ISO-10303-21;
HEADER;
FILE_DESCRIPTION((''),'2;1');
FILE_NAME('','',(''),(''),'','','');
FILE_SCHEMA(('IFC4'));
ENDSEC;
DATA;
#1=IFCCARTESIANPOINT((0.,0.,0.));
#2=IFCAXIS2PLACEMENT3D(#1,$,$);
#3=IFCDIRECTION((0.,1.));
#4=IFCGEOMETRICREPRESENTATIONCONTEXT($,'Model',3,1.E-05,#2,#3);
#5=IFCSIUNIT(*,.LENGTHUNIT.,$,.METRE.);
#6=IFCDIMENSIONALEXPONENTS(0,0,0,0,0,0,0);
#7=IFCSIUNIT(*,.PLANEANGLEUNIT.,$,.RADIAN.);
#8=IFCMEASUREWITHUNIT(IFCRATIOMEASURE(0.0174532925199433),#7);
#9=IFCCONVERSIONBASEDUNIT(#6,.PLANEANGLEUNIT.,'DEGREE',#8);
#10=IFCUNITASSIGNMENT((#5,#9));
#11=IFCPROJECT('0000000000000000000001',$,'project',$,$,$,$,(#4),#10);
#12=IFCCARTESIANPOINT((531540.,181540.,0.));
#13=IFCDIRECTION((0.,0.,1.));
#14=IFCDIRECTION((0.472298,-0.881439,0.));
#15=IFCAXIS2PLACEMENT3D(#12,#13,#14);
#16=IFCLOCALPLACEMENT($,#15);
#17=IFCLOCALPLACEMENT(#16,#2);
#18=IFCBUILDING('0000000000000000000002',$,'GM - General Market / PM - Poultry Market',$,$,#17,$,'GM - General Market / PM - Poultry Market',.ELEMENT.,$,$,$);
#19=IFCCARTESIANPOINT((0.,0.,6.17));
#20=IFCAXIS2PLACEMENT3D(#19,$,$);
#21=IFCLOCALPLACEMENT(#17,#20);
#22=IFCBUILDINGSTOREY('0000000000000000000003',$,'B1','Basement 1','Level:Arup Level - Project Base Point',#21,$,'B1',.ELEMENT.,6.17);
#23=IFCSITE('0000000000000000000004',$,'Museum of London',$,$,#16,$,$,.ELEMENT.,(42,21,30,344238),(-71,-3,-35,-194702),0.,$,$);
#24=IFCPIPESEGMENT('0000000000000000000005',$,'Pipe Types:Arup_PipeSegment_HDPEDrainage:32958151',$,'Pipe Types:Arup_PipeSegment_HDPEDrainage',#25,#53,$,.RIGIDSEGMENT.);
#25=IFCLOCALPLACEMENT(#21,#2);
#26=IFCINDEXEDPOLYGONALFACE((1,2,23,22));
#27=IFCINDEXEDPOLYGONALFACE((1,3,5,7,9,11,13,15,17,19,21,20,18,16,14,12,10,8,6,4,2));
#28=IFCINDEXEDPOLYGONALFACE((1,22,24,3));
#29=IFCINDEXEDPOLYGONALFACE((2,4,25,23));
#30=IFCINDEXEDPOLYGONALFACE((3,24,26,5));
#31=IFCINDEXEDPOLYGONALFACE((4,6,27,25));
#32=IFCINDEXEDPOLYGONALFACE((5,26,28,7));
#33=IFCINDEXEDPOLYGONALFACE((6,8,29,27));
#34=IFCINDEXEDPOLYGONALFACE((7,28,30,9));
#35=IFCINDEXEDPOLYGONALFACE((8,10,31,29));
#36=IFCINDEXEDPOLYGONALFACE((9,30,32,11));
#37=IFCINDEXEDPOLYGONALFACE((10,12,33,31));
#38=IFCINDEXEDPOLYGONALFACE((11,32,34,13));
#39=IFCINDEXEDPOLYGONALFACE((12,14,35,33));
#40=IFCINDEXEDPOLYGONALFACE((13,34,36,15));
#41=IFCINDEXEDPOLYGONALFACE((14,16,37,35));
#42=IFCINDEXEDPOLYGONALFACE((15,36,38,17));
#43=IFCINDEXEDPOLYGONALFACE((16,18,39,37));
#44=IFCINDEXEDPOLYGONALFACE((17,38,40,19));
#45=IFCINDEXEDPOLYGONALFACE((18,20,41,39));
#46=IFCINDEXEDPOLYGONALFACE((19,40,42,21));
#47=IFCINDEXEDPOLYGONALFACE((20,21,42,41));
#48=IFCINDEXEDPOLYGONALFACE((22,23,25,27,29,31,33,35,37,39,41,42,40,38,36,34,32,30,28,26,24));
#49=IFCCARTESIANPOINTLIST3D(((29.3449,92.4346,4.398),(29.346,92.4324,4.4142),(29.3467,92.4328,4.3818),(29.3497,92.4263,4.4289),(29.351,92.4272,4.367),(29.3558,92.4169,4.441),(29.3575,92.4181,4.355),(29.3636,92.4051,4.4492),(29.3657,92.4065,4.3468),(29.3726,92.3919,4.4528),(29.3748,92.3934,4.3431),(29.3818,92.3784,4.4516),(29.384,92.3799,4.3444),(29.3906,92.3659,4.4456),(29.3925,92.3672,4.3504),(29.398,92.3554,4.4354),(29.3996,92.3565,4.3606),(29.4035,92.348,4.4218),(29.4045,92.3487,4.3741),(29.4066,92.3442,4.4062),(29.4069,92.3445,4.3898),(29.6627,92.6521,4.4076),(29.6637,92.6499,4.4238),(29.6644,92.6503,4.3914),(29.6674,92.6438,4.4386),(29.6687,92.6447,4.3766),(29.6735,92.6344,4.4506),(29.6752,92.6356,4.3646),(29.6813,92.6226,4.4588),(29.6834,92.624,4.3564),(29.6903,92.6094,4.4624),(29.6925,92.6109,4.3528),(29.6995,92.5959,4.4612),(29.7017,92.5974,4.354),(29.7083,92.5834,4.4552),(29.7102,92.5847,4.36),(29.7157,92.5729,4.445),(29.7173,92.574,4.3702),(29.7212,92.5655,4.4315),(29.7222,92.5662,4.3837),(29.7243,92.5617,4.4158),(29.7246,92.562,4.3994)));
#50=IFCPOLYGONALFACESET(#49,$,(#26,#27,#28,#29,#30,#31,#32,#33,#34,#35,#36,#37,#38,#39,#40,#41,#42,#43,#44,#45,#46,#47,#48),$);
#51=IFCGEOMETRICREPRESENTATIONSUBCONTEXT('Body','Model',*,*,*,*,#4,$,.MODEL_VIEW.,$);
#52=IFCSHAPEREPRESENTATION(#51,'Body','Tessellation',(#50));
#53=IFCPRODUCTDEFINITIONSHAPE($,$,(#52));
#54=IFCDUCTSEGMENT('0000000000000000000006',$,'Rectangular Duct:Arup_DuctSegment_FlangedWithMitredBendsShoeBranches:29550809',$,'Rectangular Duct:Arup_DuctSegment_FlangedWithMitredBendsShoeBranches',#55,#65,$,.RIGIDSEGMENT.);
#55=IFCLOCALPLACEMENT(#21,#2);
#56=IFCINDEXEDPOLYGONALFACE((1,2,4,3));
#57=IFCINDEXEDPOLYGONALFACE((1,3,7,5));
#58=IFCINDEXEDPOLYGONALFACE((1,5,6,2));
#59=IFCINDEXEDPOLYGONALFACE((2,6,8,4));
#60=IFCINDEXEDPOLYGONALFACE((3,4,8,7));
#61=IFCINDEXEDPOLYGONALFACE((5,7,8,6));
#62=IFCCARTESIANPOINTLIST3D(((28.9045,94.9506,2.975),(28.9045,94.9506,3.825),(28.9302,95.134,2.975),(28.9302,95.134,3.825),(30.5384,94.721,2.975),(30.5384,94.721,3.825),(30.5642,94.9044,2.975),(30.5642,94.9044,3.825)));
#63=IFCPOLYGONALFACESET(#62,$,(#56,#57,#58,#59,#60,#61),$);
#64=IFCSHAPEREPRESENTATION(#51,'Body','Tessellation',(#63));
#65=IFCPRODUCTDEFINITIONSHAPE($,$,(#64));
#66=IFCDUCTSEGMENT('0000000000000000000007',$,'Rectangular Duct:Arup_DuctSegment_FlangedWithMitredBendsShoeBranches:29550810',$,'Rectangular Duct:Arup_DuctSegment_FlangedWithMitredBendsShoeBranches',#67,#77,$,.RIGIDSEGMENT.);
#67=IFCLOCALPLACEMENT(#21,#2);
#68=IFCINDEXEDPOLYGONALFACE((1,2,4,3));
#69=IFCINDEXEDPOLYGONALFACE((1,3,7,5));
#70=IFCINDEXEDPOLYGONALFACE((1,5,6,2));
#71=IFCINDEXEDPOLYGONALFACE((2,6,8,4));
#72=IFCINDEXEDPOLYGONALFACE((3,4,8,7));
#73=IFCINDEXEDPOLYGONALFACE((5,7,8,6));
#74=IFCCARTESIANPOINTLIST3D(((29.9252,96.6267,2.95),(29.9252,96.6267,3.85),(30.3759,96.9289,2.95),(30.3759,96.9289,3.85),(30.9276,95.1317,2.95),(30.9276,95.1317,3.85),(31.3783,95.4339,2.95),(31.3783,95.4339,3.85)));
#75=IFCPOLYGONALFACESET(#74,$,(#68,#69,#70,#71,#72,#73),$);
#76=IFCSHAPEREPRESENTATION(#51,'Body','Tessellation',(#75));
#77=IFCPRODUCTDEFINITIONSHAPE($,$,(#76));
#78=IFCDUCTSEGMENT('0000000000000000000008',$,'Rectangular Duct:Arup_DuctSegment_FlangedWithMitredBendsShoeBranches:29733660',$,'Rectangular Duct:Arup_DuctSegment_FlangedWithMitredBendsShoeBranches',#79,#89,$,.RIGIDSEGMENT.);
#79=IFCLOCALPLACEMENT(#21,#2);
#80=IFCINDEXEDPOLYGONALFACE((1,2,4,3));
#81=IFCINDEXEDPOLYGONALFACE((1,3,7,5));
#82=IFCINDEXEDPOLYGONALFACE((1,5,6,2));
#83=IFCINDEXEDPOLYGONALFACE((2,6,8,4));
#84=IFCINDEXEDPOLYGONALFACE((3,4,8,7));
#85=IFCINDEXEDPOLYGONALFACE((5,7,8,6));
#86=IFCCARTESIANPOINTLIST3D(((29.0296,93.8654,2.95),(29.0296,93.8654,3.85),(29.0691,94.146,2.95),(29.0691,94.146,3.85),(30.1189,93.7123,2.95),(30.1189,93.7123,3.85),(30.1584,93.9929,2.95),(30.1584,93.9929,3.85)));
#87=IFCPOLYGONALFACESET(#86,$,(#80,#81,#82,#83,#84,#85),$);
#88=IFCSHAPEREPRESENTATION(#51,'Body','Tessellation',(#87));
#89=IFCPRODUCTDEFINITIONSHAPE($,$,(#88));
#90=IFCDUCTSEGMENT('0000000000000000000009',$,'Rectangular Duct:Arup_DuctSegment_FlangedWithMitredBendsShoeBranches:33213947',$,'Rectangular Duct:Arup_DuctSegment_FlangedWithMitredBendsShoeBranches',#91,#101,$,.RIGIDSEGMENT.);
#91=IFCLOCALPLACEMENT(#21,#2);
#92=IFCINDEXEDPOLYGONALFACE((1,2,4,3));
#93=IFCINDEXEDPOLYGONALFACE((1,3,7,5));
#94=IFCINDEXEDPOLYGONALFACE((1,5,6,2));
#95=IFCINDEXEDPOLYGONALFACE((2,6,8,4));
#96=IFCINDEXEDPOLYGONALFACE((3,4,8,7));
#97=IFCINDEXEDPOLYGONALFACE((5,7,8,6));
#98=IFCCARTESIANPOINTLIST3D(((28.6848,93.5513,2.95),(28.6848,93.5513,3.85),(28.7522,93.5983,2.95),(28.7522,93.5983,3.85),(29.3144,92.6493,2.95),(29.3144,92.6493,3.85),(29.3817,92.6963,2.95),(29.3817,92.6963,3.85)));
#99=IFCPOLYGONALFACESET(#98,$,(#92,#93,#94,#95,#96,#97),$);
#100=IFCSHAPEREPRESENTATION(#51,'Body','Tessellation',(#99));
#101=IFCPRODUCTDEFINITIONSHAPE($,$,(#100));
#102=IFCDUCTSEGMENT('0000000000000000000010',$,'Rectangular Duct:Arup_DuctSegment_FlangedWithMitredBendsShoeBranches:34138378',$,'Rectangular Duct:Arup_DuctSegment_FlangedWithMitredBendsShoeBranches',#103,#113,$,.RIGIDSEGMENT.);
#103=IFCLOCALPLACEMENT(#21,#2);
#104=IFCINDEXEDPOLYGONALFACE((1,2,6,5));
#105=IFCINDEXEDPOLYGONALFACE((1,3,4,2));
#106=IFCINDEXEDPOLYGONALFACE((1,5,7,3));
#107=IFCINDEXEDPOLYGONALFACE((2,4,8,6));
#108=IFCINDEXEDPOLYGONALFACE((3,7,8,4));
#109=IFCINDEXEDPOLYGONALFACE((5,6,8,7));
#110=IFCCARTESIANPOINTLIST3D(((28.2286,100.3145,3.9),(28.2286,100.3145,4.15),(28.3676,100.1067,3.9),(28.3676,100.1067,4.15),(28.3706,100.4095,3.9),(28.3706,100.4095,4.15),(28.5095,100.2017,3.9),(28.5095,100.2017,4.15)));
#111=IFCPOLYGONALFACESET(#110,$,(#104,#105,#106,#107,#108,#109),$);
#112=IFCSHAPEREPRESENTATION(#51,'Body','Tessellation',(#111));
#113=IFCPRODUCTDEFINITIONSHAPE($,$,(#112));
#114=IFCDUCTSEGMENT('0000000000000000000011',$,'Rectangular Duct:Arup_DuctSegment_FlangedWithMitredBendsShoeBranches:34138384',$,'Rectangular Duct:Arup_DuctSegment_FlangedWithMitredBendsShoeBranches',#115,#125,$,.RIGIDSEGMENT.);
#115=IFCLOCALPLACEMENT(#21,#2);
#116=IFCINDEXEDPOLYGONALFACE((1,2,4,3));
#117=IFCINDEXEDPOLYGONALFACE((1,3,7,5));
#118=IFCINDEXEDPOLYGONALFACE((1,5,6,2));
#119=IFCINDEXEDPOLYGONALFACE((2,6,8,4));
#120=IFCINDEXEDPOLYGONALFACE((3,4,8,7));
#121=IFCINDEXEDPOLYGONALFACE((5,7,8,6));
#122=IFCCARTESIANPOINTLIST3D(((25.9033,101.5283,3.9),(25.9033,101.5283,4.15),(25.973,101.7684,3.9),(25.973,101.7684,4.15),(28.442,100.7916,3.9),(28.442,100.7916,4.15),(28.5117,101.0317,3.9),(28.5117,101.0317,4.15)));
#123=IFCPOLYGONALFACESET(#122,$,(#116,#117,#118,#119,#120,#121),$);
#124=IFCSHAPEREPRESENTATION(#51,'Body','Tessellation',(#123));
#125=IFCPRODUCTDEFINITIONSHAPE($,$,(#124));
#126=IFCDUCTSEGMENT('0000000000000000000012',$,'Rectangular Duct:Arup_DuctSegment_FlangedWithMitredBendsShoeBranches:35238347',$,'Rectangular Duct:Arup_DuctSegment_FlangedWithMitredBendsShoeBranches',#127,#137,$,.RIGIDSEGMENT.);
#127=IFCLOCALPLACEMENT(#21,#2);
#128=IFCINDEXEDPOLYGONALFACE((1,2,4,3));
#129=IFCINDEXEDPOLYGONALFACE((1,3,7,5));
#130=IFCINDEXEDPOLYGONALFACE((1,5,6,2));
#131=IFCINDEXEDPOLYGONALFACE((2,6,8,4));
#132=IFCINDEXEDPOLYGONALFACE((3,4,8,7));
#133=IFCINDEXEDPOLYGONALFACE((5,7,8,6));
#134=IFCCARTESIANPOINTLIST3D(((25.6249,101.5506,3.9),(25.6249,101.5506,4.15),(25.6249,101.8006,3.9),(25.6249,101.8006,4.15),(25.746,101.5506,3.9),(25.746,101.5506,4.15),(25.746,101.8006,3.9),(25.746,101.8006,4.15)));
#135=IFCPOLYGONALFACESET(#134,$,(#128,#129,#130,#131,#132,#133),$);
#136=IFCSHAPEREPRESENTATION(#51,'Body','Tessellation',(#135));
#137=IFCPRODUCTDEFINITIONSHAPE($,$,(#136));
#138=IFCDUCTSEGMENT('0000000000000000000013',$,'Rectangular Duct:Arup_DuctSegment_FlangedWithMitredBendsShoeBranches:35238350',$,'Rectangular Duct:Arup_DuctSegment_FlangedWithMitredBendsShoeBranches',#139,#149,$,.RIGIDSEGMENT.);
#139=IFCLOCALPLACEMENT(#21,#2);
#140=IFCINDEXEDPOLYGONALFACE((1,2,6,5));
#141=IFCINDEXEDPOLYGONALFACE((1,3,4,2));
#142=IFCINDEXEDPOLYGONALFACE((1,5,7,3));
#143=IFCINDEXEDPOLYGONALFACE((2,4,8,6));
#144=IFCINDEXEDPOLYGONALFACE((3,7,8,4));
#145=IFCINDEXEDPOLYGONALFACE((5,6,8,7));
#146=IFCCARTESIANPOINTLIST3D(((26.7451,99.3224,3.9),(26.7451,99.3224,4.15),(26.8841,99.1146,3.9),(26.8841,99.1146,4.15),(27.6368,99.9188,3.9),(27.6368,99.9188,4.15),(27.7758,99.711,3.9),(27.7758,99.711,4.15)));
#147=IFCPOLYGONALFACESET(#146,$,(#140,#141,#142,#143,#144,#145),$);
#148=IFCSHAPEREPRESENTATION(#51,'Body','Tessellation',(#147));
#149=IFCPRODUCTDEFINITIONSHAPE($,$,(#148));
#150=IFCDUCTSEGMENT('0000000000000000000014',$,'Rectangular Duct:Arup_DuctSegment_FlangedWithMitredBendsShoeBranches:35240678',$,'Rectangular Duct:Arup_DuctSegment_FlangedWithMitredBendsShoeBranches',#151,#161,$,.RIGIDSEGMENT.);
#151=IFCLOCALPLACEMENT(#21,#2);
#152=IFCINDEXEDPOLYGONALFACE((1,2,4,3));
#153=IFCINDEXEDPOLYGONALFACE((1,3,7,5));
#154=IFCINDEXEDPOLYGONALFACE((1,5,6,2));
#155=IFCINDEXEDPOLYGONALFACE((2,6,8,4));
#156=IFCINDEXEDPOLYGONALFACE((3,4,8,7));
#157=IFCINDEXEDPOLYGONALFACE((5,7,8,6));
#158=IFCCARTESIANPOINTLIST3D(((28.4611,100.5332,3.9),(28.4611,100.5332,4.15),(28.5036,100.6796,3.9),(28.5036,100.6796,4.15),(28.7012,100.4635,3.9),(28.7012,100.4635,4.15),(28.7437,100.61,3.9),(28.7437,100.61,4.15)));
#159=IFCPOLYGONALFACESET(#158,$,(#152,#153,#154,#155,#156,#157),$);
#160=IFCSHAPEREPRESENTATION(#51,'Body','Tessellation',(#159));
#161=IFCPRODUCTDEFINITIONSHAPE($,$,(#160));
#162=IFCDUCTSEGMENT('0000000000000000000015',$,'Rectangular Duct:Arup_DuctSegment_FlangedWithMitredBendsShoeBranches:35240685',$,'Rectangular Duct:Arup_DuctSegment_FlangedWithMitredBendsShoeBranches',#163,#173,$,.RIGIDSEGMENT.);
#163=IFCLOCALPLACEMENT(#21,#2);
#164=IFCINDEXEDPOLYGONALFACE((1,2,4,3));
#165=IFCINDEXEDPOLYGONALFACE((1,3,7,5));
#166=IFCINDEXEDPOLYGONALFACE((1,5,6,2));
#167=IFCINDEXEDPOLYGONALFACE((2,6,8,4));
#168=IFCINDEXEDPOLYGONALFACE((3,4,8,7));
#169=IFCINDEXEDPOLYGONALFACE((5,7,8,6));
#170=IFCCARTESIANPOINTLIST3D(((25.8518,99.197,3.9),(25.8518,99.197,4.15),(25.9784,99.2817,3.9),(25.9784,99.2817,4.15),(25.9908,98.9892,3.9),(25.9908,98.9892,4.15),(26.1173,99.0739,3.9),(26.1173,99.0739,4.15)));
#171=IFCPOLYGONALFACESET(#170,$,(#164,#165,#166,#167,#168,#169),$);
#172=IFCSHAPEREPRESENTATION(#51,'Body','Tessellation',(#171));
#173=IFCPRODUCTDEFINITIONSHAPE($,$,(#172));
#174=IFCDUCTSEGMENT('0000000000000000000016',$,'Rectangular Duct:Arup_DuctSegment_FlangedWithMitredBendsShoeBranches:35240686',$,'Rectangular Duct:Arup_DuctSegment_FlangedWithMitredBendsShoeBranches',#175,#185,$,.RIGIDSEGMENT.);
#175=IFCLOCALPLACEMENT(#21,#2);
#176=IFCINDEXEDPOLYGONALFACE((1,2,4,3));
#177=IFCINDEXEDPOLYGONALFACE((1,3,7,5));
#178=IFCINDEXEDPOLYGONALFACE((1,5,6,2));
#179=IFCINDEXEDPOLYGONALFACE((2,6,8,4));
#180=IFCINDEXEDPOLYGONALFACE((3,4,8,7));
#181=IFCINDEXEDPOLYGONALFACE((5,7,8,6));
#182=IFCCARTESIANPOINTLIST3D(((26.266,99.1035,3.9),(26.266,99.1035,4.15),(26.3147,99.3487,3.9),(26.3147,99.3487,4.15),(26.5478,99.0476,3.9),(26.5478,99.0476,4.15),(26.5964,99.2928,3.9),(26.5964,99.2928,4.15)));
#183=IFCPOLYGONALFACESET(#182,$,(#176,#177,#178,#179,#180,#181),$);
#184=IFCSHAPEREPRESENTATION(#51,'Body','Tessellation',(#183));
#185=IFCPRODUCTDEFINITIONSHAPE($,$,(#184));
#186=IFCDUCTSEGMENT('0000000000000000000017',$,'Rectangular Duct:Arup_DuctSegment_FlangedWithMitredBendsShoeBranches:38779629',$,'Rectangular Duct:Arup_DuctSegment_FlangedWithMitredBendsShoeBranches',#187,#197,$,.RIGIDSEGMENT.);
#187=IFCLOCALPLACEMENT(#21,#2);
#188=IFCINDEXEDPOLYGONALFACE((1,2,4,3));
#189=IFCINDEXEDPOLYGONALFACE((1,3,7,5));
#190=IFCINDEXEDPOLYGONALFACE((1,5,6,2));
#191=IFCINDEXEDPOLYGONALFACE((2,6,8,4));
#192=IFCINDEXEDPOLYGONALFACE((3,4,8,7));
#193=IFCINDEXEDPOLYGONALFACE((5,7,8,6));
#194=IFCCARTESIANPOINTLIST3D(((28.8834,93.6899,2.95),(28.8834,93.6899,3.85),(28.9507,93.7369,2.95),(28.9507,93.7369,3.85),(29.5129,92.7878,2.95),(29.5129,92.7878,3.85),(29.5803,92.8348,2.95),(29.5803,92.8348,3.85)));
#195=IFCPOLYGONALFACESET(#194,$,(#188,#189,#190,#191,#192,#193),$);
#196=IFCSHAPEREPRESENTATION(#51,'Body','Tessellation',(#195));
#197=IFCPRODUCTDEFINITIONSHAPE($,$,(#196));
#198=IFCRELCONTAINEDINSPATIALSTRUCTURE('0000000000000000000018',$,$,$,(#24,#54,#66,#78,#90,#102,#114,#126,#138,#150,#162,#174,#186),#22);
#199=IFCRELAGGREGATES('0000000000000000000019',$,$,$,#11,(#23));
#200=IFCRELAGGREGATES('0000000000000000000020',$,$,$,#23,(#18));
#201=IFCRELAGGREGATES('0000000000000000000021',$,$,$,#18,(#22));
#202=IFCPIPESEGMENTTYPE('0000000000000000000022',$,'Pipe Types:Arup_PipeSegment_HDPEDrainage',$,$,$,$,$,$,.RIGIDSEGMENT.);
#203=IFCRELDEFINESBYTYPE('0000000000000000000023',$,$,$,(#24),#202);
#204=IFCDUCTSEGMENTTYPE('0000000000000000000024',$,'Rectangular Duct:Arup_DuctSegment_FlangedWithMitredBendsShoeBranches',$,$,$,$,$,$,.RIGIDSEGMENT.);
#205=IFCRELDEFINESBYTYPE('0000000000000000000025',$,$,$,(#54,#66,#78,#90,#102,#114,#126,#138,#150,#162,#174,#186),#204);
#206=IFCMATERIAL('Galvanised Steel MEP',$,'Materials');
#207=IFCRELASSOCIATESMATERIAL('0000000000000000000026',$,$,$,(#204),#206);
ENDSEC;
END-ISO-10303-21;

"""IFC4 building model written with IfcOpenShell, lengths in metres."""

from ifc_helpers import new_model, entity, si_unit, converted_unit, direction, frame, frame_2d, origin, origin_2d_with_axis, place, context, subcontext, project, spatial, rectangle, circle, extrude, material, type_object, element, save


model = new_model("IFC4")

# Units and contexts
model_context = context("Model", 3, precision=1e-05, world=origin(), true_north=direction((0.0, 1.0)))
body_context = subcontext(model_context, "Body", "Model", "MODEL_VIEW")
ifc_project = project(units=[si_unit("LENGTHUNIT", "METRE"), converted_unit("PLANEANGLEUNIT", "DEGREE", entity("IfcRatioMeasure", 0.0174532925199433), si_unit("PLANEANGLEUNIT", "RADIAN"), dimensions=[0, 0, 0, 0, 0, 0, 0])], contexts=[model_context])

# Site, building, storey
site_placement = place(None, frame((531540.0, 181540.0, 0.0), z_axis=(0.0, 0.0, 1.0), x_axis=(0.472298, -0.881439, 0.0)))
site = spatial("IfcSite", under=ifc_project, at=site_placement, Name="Museum of London", CompositionType="ELEMENT", RefLatitude=(42, 21, 30, 344238), RefLongitude=(-71, -3, -35, -194702), RefElevation=0.0)
building_placement = place(site_placement, origin())
building = spatial("IfcBuilding", under=site, at=building_placement, Name="GM - General Market / PM - Poultry Market", LongName="GM - General Market / PM - Poultry Market", CompositionType="ELEMENT")
storey_placement = place(building_placement, frame((0.0, 0.0, 6.17)))
storey = spatial("IfcBuildingStorey", under=building, at=storey_placement, Name="B1", Description="Basement 1", ObjectType="Level:Arup Level - Project Base Point", LongName="B1", CompositionType="ELEMENT", Elevation=6.17)

# Pipe segment
pipe_segment_type_1 = type_object("IfcPipeSegmentType", Name="Pipe Types:Arup_PipeSegment_HDPEDrainage", PredefinedType="RIGIDSEGMENT")
pipe_segment_1_placement = place(storey_placement, frame((29.3433, 92.3423, 4.3414)))
element("IfcPipeSegment", 1, at=pipe_segment_1_placement, inside=storey, type_object=pipe_segment_type_1, Name="Pipe Types:Arup_PipeSegment_HDPEDrainage:32958151", ObjectType="Pipe Types:Arup_PipeSegment_HDPEDrainage", PredefinedType="RIGIDSEGMENT", context=body_context, shape_type="SweptSolid", body=[
    extrude(circle(Radius=0.055, at=origin_2d_with_axis()), frame((0.0327, 0.047, 0.0566), z_axis=(0.824906, 0.564717, 0.024992), x_axis=(-0.564893, 0.825164, 0.0)), (0.0, 0.0, 1.0), 0.3851),
])

# Duct segments
ifc_material_1 = material(Name="Galvanised Steel MEP", Category="Materials")
duct_segment_type = type_object("IfcDuctSegmentType", Name="Rectangular Duct:Arup_DuctSegment_FlangedWithMitredBendsShoeBranches", PredefinedType="RIGIDSEGMENT", material=ifc_material_1)
duct_segment_1_placement = place(storey_placement, frame((28.9045, 94.721, 2.975)))
element("IfcDuctSegment", 2, at=duct_segment_1_placement, inside=storey, type_object=duct_segment_type, Name="Rectangular Duct:Arup_DuctSegment_FlangedWithMitredBendsShoeBranches:29550809", ObjectType="Rectangular Duct:Arup_DuctSegment_FlangedWithMitredBendsShoeBranches", PredefinedType="RIGIDSEGMENT", context=body_context, shape_type="SweptSolid", body=[
    extrude(rectangle(XDim=0.1852, YDim=1.65, at=origin_2d_with_axis()), frame((0.8299, 0.2065, 0.0), z_axis=(0.0, 0.0, 1.0), x_axis=(-0.139173, -0.990268, 0.0)), (0.0, 0.0, 1.0), 0.85),
])
duct_segment_2_placement = place(storey_placement, frame((29.9252, 95.1317, 2.95)))
element("IfcDuctSegment", 3, at=duct_segment_2_placement, inside=storey, type_object=duct_segment_type, Name="Rectangular Duct:Arup_DuctSegment_FlangedWithMitredBendsShoeBranches:29550810", ObjectType="Rectangular Duct:Arup_DuctSegment_FlangedWithMitredBendsShoeBranches", PredefinedType="RIGIDSEGMENT", context=body_context, shape_type="SweptSolid", body=[
    extrude(rectangle(XDim=0.5426, YDim=1.8, at=frame_2d((0.0, 0.0), x_axis=(1.0, 0.0))), frame((0.7266, 0.8986, 0.0), z_axis=(0.0, 0.0, 1.0), x_axis=(-0.830574, -0.556908, 0.0)), (0.0, 0.0, 1.0), 0.9),
])
duct_segment_3_placement = place(storey_placement, frame((29.0296, 93.7123, 2.95)))
element("IfcDuctSegment", 4, at=duct_segment_3_placement, inside=storey, type_object=duct_segment_type, Name="Rectangular Duct:Arup_DuctSegment_FlangedWithMitredBendsShoeBranches:29733660", ObjectType="Rectangular Duct:Arup_DuctSegment_FlangedWithMitredBendsShoeBranches", PredefinedType="RIGIDSEGMENT", context=body_context, shape_type="SweptSolid", body=[
    extrude(rectangle(XDim=0.2833, YDim=1.1, at=frame_2d((0.0, 0.0), x_axis=(1.0, 0.0))), frame((0.5644, 0.2168, 0.0), z_axis=(0.0, 0.0, 1.0), x_axis=(0.139173, 0.990268, 0.0)), (0.0, 0.0, 1.0), 0.9),
])
duct_segment_4_placement = place(storey_placement, frame((28.6848, 92.6493, 2.95)))
element("IfcDuctSegment", 5, at=duct_segment_4_placement, inside=storey, type_object=duct_segment_type, Name="Rectangular Duct:Arup_DuctSegment_FlangedWithMitredBendsShoeBranches:33213947", ObjectType="Rectangular Duct:Arup_DuctSegment_FlangedWithMitredBendsShoeBranches", PredefinedType="RIGIDSEGMENT", context=body_context, shape_type="SweptSolid", body=[
    extrude(rectangle(XDim=0.0821, YDim=1.1, at=frame_2d((0.0, 0.0), x_axis=(1.0, 0.0))), frame((0.3484, 0.4745, 0.0), z_axis=(0.0, 0.0, 1.0), x_axis=(-0.820027, -0.572325, 0.0)), (0.0, 0.0, 1.0), 0.9),
])
duct_segment_5_placement = place(storey_placement, frame((28.2286, 100.1067, 3.9)))
element("IfcDuctSegment", 6, at=duct_segment_5_placement, inside=storey, type_object=duct_segment_type, Name="Rectangular Duct:Arup_DuctSegment_FlangedWithMitredBendsShoeBranches:34138378", ObjectType="Rectangular Duct:Arup_DuctSegment_FlangedWithMitredBendsShoeBranches", PredefinedType="RIGIDSEGMENT", context=body_context, shape_type="SweptSolid", body=[
    extrude(rectangle(XDim=0.1708, YDim=0.25, at=frame_2d((0.0, 0.0), x_axis=(1.0, 0.0))), frame((0.1405, 0.1514, 0.0), z_axis=(0.0, 0.0, 1.0), x_axis=(-0.831246, -0.555905, 0.0)), (0.0, 0.0, 1.0), 0.25),
])
duct_segment_6_placement = place(storey_placement, frame((25.9033, 100.7916, 3.9)))
element("IfcDuctSegment", 7, at=duct_segment_6_placement, inside=storey, type_object=duct_segment_type, Name="Rectangular Duct:Arup_DuctSegment_FlangedWithMitredBendsShoeBranches:34138384", ObjectType="Rectangular Duct:Arup_DuctSegment_FlangedWithMitredBendsShoeBranches", PredefinedType="RIGIDSEGMENT", context=body_context, shape_type="SweptSolid", body=[
    extrude(rectangle(XDim=2.6434, YDim=0.25, at=frame_2d((0.0, 0.0), x_axis=(1.0, 0.0))), frame((1.3042, 0.4884, 0.0), z_axis=(0.0, 0.0, 1.0), x_axis=(0.960383, -0.278682, 0.0)), (0.0, 0.0, 1.0), 0.25),
])
duct_segment_7_placement = place(storey_placement, frame((25.6249, 101.5506, 3.9)))
element("IfcDuctSegment", 8, at=duct_segment_7_placement, inside=storey, type_object=duct_segment_type, Name="Rectangular Duct:Arup_DuctSegment_FlangedWithMitredBendsShoeBranches:35238347", ObjectType="Rectangular Duct:Arup_DuctSegment_FlangedWithMitredBendsShoeBranches", PredefinedType="RIGIDSEGMENT", context=body_context, shape_type="SweptSolid", body=[
    extrude(rectangle(XDim=0.1211, YDim=0.25, at=frame_2d((0.0, 0.0), x_axis=(1.0, 0.0))), frame((0.0605, 0.125, 0.0), z_axis=(0.0, 0.0, 1.0), x_axis=(-1.0, 0.0, 0.0)), (0.0, 0.0, 1.0), 0.25),
])
duct_segment_8_placement = place(storey_placement, frame((26.7451, 99.1146, 3.9)))
element("IfcDuctSegment", 9, at=duct_segment_8_placement, inside=storey, type_object=duct_segment_type, Name="Rectangular Duct:Arup_DuctSegment_FlangedWithMitredBendsShoeBranches:35238350", ObjectType="Rectangular Duct:Arup_DuctSegment_FlangedWithMitredBendsShoeBranches", PredefinedType="RIGIDSEGMENT", context=body_context, shape_type="SweptSolid", body=[
    extrude(rectangle(XDim=1.0727, YDim=0.25, at=frame_2d((0.0, 0.0), x_axis=(1.0, 0.0))), frame((0.5153, 0.4021, 0.0), z_axis=(0.0, 0.0, 1.0), x_axis=(0.831246, 0.555905, 0.0)), (0.0, 0.0, 1.0), 0.25),
])
duct_segment_9_placement = place(storey_placement, frame((28.4611, 100.4635, 3.9)))
element("IfcDuctSegment", 10, at=duct_segment_9_placement, inside=storey, type_object=duct_segment_type, Name="Rectangular Duct:Arup_DuctSegment_FlangedWithMitredBendsShoeBranches:35240678", ObjectType="Rectangular Duct:Arup_DuctSegment_FlangedWithMitredBendsShoeBranches", PredefinedType="RIGIDSEGMENT", context=body_context, shape_type="SweptSolid", body=[
    extrude(rectangle(XDim=0.1525, YDim=0.25, at=frame_2d((0.0, 0.0), x_axis=(1.0, 0.0))), frame((0.1413, 0.1081, 0.0), z_axis=(0.0, 0.0, 1.0), x_axis=(0.278679, 0.960384, 0.0)), (0.0, 0.0, 1.0), 0.25),
])
duct_segment_10_placement = place(storey_placement, frame((25.8518, 98.9892, 3.9)))
element("IfcDuctSegment", 11, at=duct_segment_10_placement, inside=storey, type_object=duct_segment_type, Name="Rectangular Duct:Arup_DuctSegment_FlangedWithMitredBendsShoeBranches:35240685", ObjectType="Rectangular Duct:Arup_DuctSegment_FlangedWithMitredBendsShoeBranches", PredefinedType="RIGIDSEGMENT", context=body_context, shape_type="SweptSolid", body=[
    extrude(rectangle(XDim=0.1523, YDim=0.25, at=origin_2d_with_axis()), frame((0.1328, 0.1462, 0.0), z_axis=(0.0, 0.0, 1.0), x_axis=(0.831246, 0.555905, 0.0)), (0.0, 0.0, 1.0), 0.25),
])
duct_segment_11_placement = place(storey_placement, frame((26.266, 99.0476, 3.9)))
element("IfcDuctSegment", 12, at=duct_segment_11_placement, inside=storey, type_object=duct_segment_type, Name="Rectangular Duct:Arup_DuctSegment_FlangedWithMitredBendsShoeBranches:35240686", ObjectType="Rectangular Duct:Arup_DuctSegment_FlangedWithMitredBendsShoeBranches", PredefinedType="RIGIDSEGMENT", context=body_context, shape_type="SweptSolid", body=[
    extrude(rectangle(XDim=0.2872, YDim=0.25, at=frame_2d((0.0, 0.0), x_axis=(1.0, 0.0))), frame((0.1652, 0.1506, 0.0), z_axis=(0.0, 0.0, 1.0), x_axis=(-0.980864, 0.194696, 0.0)), (0.0, 0.0, 1.0), 0.25),
])
duct_segment_12_placement = place(storey_placement, frame((28.8834, 92.7878, 2.95)))
element("IfcDuctSegment", 13, at=duct_segment_12_placement, inside=storey, type_object=duct_segment_type, Name="Rectangular Duct:Arup_DuctSegment_FlangedWithMitredBendsShoeBranches:38779629", ObjectType="Rectangular Duct:Arup_DuctSegment_FlangedWithMitredBendsShoeBranches", PredefinedType="RIGIDSEGMENT", context=body_context, shape_type="SweptSolid", body=[
    extrude(rectangle(XDim=0.0821, YDim=1.1, at=frame_2d((0.0, 0.0), x_axis=(1.0, 0.0))), frame((0.3484, 0.4745, 0.0), z_axis=(0.0, 0.0, 1.0), x_axis=(-0.820027, -0.572325, 0.0)), (0.0, 0.0, 1.0), 0.9),
])

save(model, "model.ifc")
